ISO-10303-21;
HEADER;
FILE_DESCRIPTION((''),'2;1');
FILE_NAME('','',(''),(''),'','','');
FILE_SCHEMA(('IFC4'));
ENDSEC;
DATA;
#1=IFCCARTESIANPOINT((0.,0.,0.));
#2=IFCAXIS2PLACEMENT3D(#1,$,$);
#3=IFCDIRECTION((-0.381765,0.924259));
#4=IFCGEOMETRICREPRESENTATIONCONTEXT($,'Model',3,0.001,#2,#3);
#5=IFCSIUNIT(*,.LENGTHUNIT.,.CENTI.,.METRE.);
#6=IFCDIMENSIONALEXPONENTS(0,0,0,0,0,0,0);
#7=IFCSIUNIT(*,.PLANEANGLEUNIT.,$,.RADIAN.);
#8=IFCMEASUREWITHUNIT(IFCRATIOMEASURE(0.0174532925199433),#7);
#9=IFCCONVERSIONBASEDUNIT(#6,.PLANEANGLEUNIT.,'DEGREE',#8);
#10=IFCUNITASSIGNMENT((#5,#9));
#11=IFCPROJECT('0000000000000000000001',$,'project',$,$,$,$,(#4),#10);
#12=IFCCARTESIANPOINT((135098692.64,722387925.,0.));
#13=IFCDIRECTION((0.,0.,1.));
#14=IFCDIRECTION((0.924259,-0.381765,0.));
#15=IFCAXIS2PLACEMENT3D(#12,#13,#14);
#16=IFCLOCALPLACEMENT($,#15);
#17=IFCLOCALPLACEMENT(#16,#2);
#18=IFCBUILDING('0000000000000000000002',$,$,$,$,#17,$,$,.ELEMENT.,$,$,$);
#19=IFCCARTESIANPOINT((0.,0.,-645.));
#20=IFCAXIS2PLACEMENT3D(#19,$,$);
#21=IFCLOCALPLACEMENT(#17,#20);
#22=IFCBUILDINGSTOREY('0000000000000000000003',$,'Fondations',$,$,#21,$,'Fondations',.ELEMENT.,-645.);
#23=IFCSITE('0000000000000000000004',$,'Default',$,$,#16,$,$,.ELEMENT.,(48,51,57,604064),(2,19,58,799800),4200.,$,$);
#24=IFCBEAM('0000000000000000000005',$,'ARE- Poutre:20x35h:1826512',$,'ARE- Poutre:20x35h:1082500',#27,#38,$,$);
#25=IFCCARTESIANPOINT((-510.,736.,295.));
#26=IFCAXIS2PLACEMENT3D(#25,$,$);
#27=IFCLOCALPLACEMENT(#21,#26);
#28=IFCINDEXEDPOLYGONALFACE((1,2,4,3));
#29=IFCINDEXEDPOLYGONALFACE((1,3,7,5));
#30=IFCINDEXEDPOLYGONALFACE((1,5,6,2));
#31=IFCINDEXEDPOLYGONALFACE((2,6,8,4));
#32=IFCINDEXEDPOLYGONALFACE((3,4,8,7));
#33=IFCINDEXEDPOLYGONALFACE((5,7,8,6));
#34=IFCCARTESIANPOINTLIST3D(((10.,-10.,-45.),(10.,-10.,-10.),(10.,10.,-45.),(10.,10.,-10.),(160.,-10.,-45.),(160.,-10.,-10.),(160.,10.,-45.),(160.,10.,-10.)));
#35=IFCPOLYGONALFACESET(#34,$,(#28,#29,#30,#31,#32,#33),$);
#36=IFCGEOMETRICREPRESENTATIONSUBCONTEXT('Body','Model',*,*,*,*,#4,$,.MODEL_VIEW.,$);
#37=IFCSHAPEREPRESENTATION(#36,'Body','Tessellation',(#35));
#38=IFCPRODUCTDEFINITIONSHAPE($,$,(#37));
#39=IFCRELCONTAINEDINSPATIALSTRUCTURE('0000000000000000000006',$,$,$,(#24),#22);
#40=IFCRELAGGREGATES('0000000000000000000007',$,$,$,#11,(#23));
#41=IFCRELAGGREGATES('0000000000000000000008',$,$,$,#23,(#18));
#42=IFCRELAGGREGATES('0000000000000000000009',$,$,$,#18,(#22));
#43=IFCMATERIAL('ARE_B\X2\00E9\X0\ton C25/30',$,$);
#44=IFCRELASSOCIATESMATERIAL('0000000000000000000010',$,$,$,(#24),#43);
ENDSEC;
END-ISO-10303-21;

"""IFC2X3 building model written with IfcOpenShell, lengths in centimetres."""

from ifc_helpers import new_model, entity, si_unit, converted_unit, direction, frame, frame_2d, origin, place, context, subcontext, project, spatial, rectangle, extrude, material, element, save


model = new_model("IFC2X3")

# Units and contexts
model_context = context("Model", 3, precision=0.001, world=origin(), true_north=direction((-0.381765, 0.924259)))
body_context = subcontext(model_context, "Body", "Model", "MODEL_VIEW")
ifc_project = project(units=[si_unit("LENGTHUNIT", "METRE", prefix="CENTI"), converted_unit("PLANEANGLEUNIT", "DEGREE", entity("IfcRatioMeasure", 0.0174532925199433), si_unit("PLANEANGLEUNIT", "RADIAN"), dimensions=[0, 0, 0, 0, 0, 0, 0])], contexts=[model_context])

# Site, building, storey
site_placement = place(None, frame((135098692.64, 722387925.0, 0.0), z_axis=(0.0, 0.0, 1.0), x_axis=(0.924259, -0.381765, 0.0)))
site = spatial("IfcSite", under=ifc_project, at=site_placement, Name="Default", CompositionType="ELEMENT", RefLatitude=(48, 51, 57, 604064), RefLongitude=(2, 19, 58, 799800), RefElevation=4200.0)
building_placement = place(site_placement, origin())
building = spatial("IfcBuilding", under=site, at=building_placement, CompositionType="ELEMENT")
storey_placement = place(building_placement, frame((0.0, 0.0, -645.0)))
storey = spatial("IfcBuildingStorey", under=building, at=storey_placement, Name="Fondations", LongName="Fondations", CompositionType="ELEMENT", Elevation=-645.0)

# Beam
ifc_material_1 = material(Name="ARE_Béton C25/30")
beam_placement = place(storey_placement, frame((-510.0, 736.0, 295.0)))
element("IfcBeam", 1, at=beam_placement, inside=storey, material=ifc_material_1, Name="ARE- Poutre:20x35h:1826512", ObjectType="ARE- Poutre:20x35h:1082500", context=body_context, shape_type="SweptSolid", body=[
    extrude(rectangle(XDim=35.0, YDim=20.0, at=frame_2d((0.0, 0.0), x_axis=(1.0, 0.0))), frame((10.0, 0.0, -27.5), z_axis=(1.0, 0.0, 0.0), x_axis=(0.0, 0.0, -1.0)), (0.0, 0.0, 1.0), 150.0),
])

save(model, "model.ifc")
